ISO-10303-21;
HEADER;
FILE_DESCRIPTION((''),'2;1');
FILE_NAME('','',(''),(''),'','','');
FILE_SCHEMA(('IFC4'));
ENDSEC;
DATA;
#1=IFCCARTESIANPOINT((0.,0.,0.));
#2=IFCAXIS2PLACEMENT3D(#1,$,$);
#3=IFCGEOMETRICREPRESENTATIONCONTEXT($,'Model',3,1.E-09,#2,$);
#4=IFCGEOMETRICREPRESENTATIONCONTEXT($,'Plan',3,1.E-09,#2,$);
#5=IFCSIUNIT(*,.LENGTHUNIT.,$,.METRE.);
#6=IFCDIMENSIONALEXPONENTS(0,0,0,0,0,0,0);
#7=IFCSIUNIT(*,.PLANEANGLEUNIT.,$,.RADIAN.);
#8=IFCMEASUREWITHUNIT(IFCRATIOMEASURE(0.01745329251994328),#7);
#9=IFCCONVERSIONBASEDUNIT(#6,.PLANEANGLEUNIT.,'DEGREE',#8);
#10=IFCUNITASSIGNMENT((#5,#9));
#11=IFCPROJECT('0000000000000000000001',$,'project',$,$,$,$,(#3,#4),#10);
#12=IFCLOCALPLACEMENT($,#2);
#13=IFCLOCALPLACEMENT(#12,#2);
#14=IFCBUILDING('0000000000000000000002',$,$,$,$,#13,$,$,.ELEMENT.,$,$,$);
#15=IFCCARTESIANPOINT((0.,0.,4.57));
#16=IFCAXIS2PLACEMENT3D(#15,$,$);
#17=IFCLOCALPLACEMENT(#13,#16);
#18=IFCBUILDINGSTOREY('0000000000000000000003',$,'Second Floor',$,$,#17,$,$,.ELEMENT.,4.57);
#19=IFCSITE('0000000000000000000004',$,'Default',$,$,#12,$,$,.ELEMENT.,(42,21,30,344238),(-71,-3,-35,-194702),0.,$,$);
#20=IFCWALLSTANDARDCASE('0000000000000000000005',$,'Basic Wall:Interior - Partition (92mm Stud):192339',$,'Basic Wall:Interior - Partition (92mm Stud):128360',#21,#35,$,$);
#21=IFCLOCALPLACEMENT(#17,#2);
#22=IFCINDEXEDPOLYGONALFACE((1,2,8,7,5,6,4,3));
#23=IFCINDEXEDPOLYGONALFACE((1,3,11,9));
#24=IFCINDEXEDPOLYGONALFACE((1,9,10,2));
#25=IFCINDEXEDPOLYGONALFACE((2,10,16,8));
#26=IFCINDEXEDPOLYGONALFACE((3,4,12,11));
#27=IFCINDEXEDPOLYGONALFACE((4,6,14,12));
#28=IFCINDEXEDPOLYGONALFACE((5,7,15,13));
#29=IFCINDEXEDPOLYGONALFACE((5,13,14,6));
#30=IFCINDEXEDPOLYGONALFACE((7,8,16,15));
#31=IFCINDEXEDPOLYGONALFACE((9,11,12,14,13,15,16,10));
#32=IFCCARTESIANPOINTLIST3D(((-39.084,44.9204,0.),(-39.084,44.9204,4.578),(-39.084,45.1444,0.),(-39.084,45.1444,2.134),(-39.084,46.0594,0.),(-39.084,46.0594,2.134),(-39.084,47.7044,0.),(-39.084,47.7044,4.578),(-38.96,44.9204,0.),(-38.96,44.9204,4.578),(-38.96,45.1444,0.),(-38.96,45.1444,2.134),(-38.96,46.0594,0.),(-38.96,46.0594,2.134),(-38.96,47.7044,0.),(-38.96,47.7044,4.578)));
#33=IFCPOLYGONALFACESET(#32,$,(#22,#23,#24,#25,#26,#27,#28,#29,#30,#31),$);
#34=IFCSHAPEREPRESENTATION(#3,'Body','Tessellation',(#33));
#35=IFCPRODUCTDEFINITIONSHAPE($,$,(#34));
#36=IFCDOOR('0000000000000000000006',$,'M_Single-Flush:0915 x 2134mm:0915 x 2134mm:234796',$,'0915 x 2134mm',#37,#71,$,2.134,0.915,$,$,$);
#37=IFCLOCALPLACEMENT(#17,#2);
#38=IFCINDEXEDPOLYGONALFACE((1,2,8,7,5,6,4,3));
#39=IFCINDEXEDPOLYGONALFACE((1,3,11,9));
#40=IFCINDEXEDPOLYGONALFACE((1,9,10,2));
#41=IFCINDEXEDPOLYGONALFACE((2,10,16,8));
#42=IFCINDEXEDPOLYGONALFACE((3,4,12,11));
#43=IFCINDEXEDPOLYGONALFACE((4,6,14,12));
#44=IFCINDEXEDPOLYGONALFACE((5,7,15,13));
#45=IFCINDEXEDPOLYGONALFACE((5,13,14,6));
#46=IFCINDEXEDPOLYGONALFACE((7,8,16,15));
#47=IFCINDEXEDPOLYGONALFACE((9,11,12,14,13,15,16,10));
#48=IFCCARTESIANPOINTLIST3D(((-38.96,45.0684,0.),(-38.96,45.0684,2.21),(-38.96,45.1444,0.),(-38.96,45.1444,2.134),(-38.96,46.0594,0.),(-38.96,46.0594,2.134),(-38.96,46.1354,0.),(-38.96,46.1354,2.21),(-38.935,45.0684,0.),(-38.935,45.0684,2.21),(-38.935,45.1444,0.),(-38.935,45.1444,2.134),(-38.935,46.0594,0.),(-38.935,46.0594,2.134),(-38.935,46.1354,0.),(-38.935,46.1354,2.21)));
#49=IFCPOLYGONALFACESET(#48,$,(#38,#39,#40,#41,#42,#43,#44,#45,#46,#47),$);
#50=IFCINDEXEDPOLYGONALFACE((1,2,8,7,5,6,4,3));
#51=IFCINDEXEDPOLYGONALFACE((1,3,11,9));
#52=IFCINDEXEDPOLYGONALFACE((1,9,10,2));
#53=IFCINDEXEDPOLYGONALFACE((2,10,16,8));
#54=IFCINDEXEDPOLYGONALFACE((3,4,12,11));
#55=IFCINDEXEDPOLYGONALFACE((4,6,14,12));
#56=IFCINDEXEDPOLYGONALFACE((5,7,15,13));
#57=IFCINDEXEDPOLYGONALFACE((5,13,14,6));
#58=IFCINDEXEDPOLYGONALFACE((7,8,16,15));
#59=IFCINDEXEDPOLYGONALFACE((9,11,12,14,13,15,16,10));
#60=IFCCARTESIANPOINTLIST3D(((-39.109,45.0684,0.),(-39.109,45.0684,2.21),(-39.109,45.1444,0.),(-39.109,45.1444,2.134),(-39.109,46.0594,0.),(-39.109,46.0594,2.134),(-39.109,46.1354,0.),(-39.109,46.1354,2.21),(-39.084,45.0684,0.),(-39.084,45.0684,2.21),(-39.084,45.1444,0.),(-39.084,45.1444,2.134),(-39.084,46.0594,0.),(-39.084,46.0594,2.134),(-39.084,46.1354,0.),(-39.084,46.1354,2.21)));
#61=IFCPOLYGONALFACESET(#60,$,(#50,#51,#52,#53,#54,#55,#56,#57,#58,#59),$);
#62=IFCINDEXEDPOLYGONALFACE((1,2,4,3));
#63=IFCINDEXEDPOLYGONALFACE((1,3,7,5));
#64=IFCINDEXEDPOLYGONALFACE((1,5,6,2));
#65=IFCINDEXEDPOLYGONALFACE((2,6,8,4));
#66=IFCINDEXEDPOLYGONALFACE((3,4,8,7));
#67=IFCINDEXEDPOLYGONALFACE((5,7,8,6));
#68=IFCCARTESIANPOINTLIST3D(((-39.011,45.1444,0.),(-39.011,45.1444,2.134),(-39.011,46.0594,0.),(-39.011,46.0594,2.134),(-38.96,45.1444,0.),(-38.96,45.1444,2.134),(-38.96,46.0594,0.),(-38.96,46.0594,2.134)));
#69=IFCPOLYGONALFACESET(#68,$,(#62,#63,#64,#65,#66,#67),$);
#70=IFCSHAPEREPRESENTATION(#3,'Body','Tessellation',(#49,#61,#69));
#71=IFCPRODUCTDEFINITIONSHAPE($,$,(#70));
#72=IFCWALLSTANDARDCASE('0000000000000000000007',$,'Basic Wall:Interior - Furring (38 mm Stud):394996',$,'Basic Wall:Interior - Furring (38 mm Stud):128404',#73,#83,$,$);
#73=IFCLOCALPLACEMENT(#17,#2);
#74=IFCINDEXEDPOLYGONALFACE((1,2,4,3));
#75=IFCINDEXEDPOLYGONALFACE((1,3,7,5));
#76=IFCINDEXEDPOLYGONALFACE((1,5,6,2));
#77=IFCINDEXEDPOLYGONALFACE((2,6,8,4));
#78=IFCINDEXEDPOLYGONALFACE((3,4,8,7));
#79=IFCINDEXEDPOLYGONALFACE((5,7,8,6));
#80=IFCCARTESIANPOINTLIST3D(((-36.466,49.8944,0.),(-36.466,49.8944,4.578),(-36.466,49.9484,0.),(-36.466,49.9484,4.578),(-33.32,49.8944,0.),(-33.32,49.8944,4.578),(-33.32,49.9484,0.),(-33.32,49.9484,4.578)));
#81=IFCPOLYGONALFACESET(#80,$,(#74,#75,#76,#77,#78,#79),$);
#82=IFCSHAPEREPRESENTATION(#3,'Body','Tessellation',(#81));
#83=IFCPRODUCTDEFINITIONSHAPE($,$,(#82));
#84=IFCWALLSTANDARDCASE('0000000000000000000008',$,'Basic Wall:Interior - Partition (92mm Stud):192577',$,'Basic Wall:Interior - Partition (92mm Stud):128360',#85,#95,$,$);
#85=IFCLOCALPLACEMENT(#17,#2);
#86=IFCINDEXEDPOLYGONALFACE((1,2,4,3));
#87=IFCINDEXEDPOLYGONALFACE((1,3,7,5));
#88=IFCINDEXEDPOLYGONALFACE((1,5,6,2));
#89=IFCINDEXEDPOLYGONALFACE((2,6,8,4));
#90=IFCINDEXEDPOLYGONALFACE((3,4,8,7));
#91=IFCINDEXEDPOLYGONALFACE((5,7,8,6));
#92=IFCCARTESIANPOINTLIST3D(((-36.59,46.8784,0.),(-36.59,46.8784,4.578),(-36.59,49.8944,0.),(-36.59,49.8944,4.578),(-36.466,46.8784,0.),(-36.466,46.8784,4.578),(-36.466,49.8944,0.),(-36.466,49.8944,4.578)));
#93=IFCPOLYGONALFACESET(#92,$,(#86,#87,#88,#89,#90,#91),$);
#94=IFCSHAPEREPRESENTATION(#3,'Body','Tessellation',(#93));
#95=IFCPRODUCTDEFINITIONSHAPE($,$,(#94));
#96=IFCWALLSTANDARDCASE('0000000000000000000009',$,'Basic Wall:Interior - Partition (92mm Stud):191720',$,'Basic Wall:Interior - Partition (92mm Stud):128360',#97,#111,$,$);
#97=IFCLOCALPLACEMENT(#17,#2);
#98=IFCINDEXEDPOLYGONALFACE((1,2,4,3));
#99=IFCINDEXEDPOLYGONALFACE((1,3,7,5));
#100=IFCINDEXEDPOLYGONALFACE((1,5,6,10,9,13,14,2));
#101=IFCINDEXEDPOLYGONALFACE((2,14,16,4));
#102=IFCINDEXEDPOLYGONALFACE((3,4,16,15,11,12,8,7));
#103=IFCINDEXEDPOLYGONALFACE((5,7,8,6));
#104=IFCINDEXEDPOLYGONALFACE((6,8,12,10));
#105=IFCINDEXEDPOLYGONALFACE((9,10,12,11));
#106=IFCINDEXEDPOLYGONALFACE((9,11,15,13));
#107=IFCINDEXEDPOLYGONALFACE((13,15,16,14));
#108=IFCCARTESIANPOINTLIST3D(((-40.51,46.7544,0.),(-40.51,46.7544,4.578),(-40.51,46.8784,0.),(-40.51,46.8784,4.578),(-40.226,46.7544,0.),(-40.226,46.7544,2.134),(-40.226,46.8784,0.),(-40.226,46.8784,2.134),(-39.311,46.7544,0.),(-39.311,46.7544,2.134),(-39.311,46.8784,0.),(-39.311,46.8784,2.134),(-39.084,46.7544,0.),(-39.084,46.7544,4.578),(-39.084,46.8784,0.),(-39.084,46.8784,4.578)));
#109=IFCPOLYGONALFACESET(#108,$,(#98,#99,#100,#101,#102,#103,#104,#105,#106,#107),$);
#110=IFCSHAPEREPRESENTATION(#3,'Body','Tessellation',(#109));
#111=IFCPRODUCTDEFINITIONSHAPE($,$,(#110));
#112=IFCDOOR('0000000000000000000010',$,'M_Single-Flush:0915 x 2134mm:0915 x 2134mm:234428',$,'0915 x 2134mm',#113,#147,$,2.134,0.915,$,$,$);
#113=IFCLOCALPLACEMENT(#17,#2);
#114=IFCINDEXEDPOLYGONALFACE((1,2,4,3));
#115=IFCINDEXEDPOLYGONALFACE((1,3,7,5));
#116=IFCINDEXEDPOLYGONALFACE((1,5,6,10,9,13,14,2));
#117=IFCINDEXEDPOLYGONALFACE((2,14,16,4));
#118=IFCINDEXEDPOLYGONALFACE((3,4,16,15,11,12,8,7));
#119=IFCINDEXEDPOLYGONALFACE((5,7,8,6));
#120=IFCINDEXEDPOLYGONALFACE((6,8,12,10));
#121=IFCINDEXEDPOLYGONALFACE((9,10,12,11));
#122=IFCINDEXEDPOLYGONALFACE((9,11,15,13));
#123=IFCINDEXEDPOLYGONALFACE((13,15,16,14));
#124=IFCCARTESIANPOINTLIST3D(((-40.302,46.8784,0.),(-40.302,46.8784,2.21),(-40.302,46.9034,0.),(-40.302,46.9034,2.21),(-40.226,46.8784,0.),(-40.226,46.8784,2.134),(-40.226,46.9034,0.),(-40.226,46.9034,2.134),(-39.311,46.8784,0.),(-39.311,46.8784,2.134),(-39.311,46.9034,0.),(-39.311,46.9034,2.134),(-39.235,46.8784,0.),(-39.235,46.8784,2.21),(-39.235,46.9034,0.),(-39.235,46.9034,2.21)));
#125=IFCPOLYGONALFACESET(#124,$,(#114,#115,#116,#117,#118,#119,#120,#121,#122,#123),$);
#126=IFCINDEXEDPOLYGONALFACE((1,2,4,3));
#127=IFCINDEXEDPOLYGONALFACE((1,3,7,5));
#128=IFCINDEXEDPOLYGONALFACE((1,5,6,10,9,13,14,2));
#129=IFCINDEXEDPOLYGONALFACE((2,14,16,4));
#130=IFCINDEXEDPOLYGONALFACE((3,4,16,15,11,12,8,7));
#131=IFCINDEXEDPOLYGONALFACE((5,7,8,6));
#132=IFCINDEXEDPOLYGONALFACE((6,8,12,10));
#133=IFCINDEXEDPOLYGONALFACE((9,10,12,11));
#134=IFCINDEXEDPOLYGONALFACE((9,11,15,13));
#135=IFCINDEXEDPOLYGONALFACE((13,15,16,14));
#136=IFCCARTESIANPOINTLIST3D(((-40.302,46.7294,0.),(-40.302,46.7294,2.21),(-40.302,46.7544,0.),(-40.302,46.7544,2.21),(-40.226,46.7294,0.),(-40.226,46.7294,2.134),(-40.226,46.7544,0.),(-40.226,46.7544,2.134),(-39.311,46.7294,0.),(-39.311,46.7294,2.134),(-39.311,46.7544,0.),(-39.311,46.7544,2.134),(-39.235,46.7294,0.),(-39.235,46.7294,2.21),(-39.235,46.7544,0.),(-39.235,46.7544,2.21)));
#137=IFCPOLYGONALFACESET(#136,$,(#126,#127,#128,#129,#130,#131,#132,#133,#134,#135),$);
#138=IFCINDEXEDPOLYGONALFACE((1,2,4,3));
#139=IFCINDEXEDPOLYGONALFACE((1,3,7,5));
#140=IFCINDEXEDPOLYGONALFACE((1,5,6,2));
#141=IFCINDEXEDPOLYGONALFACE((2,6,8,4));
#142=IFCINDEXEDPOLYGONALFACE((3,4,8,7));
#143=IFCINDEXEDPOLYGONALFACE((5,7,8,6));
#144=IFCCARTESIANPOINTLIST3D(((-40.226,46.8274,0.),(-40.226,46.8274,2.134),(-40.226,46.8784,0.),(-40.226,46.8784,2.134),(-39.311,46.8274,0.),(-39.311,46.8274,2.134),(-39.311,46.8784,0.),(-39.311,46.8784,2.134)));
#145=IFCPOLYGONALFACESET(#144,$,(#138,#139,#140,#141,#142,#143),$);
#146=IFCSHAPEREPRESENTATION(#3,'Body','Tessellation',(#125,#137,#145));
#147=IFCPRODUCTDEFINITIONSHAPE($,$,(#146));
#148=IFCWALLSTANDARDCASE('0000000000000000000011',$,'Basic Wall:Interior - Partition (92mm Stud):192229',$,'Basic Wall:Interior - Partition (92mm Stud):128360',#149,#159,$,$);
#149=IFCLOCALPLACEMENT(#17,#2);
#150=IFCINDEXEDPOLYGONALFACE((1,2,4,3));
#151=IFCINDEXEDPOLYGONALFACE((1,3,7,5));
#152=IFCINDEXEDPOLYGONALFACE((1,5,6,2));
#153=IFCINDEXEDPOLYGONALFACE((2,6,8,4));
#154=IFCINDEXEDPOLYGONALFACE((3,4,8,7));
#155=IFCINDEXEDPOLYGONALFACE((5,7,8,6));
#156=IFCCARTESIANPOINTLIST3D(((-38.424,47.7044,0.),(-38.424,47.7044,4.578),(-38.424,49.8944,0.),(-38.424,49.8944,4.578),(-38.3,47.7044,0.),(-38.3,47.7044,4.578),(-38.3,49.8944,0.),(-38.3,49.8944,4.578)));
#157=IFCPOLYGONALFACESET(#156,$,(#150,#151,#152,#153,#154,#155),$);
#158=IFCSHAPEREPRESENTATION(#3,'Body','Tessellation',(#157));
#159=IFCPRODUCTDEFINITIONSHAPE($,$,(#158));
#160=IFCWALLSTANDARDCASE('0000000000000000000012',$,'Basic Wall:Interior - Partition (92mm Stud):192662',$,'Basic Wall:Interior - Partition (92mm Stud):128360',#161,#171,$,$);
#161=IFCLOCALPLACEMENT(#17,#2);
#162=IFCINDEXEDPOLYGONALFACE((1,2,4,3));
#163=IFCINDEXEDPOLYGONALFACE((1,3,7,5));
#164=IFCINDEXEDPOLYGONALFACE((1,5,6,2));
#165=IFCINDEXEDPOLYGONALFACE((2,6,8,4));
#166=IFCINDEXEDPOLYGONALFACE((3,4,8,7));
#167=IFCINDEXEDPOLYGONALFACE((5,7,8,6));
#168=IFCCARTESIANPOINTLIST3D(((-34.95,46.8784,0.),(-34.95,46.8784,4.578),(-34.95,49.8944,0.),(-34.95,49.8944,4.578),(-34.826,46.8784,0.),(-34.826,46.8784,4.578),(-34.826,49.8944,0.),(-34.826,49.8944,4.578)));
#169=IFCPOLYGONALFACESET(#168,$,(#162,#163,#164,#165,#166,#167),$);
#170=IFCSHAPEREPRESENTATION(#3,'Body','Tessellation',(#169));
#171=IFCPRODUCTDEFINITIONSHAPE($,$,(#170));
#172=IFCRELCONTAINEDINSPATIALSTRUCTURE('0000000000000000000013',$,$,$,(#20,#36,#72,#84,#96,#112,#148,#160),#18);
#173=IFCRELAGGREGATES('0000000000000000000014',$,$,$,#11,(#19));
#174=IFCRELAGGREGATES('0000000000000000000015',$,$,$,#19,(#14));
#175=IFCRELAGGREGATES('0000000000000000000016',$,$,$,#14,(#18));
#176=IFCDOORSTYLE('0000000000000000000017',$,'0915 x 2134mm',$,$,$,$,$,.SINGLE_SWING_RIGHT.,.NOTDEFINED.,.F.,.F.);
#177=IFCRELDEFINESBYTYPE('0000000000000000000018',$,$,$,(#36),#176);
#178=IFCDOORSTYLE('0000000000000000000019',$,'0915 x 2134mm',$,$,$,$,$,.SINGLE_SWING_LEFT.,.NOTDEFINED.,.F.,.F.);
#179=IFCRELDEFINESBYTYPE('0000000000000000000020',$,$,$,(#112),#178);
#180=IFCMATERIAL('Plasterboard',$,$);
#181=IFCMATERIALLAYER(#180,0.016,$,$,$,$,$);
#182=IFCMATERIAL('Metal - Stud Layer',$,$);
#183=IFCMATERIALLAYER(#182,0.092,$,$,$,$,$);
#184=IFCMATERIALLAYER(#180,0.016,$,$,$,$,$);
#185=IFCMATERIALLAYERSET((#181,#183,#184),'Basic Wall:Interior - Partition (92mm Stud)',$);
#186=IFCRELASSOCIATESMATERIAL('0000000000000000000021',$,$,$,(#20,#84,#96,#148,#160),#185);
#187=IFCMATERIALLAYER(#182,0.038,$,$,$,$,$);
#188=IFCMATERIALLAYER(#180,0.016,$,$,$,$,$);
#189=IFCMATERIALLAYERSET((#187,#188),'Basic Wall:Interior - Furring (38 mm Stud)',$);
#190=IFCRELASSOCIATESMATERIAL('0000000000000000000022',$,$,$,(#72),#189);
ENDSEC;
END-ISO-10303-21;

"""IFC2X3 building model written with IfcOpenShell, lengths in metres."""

from ifc_helpers import new_model, entity, si_unit, converted_unit, frame, frame_2d, origin, origin_2d_with_axis, place, context, project, spatial, polyline, rectangle, outline, extrude, source, transform, mapped, material, layer, layer_set, layer_usage, type_object, type_shapes, element, fill, save


model = new_model("IFC2X3")

# Units and contexts
model_context = context("Model", 3, precision=1e-09, world=origin())
plan_context = context("Plan", 3, precision=1e-09, world=origin())
ifc_project = project(units=[si_unit("LENGTHUNIT", "METRE"), converted_unit("PLANEANGLEUNIT", "DEGREE", entity("IfcRatioMeasure", 0.01745329251994328), si_unit("PLANEANGLEUNIT", "RADIAN"), dimensions=[0, 0, 0, 0, 0, 0, 0])], contexts=[model_context, plan_context])

# Site, building, storey
site_placement = place(None, origin())
site = spatial("IfcSite", under=ifc_project, at=site_placement, Name="Default", CompositionType="ELEMENT", RefLatitude=(42, 21, 30, 344238), RefLongitude=(-71, -3, -35, -194702), RefElevation=0.0)
building_placement = place(site_placement, origin())
building = spatial("IfcBuilding", under=site, at=building_placement, CompositionType="ELEMENT")
storey_placement = place(building_placement, frame((0.0, 0.0, 4.57)))
storey = spatial("IfcBuildingStorey", under=building, at=storey_placement, Name="Second Floor", CompositionType="ELEMENT", Elevation=4.57)

# Wall, opening, door
ifc_material_1 = material(Name="Plasterboard")
ifc_layer_1 = layer(ifc_material_1, 0.016)
ifc_material_2 = material(Name="Metal - Stud Layer")
ifc_layer_2 = layer(ifc_material_2, 0.092)
ifc_layer_3 = layer(ifc_material_1, 0.016)
ifc_layer_set_1 = layer_set([ifc_layer_1, ifc_layer_2, ifc_layer_3], Name="Basic Wall:Interior - Partition (92mm Stud)")
ifc_layer_usage_1 = layer_usage(ifc_layer_set_1, "AXIS2", "NEGATIVE", 0.062)
wall_1_placement = place(storey_placement, frame((-39.022, 47.7044, 0.0), z_axis=(0.0, 0.0, 1.0), x_axis=(0.0, -1.0, 0.0)))
wall_1 = element("IfcWallStandardCase", 1, at=wall_1_placement, inside=storey, material=ifc_layer_usage_1, Name="Basic Wall:Interior - Partition (92mm Stud):192339", ObjectType="Basic Wall:Interior - Partition (92mm Stud):128360", context=model_context, shape_type="SweptSolid", body=[
    extrude(rectangle(XDim=2.784, YDim=0.124, at=frame_2d((1.392, 0.0), x_axis=(-1.0, 0.0))), origin(), (0.0, 0.0, 1.0), 4.578),
])
opening_1_placement = place(wall_1_placement, frame((1.645, -0.062, 0.0)))
opening_1 = element("IfcOpeningElement", 2, at=opening_1_placement, cuts=wall_1, ObjectType="Opening", context=model_context, shape_type="SweptSolid", body=[
    extrude(rectangle(XDim=0.915, YDim=2.134, at=frame_2d((1.067, 0.4575), x_axis=(0.0, 1.0))), frame((0.0, 0.0, 0.0), z_axis=(0.0, 1.0, 0.0), x_axis=(0.0, 0.0, 1.0)), (0.0, 0.0, 1.0), 0.124),
])
door_style_1 = type_object("IfcDoorStyle", Name="0915 x 2134mm", ConstructionType="NOTDEFINED", OperationType="SINGLE_SWING_RIGHT", ParameterTakesPrecedence=False, Sizeable=False)
shared_shape_1 = source(origin(), model_context, "Body", "SweptSolid", [
    extrude(outline(polyline([(-0.5335, -1.124), (0.5335, -1.124), (0.5335, 1.086), (0.4575, 1.086), (0.4575, -1.048), (-0.4575, -1.048), (-0.4575, 1.086), (-0.5335, 1.086), (-0.5335, -1.124)])), frame((0.4575, 0.124, 1.086), z_axis=(0.0, 1.0, 0.0), x_axis=(1.0, 0.0, 0.0)), (0.0, 0.0, 1.0), 0.025),
    extrude(outline(polyline([(-1.124, -0.5335), (1.086, -0.5335), (1.086, -0.4575), (-1.048, -0.4575), (-1.048, 0.4575), (1.086, 0.4575), (1.086, 0.5335), (-1.124, 0.5335), (-1.124, -0.5335)])), frame((0.4575, -0.025, 1.086), z_axis=(0.0, 1.0, 0.0), x_axis=(0.0, 0.0, -1.0)), (0.0, 0.0, 1.0), 0.025),
    extrude(rectangle(XDim=0.051, YDim=0.915, at=origin_2d_with_axis()), frame((0.4575, 0.0985, 0.0), z_axis=(0.0, 0.0, 1.0), x_axis=(0.0, 1.0, 0.0)), (0.0, 0.0, 1.0), 2.134),
])
type_shapes(door_style_1, [shared_shape_1])
door_1_placement = place(opening_1_placement, origin())
door_1 = element("IfcDoor", 3, at=door_1_placement, inside=storey, type_object=door_style_1, Name="M_Single-Flush:0915 x 2134mm:0915 x 2134mm:234796", ObjectType="0915 x 2134mm", OverallHeight=2.134, OverallWidth=0.915, context=model_context, shape_type="MappedRepresentation", body=[
    mapped(shared_shape_1, transform((0.0, 0.0, 0.0), scale=1.0)),
])
fill(opening_1, door_1)

# Walls
ifc_layer_4 = layer(ifc_material_2, 0.038)
ifc_layer_5 = layer(ifc_material_1, 0.016)
ifc_layer_set_2 = layer_set([ifc_layer_4, ifc_layer_5], Name="Basic Wall:Interior - Furring (38 mm Stud)")
ifc_layer_usage_2 = layer_usage(ifc_layer_set_2, "AXIS2", "NEGATIVE", 0.027)
wall_2_placement = place(storey_placement, frame((-36.466, 49.9214, 0.0)))
element("IfcWallStandardCase", 4, at=wall_2_placement, inside=storey, material=ifc_layer_usage_2, Name="Basic Wall:Interior - Furring (38 mm Stud):394996", ObjectType="Basic Wall:Interior - Furring (38 mm Stud):128404", context=model_context, shape_type="SweptSolid", body=[
    extrude(rectangle(XDim=3.146, YDim=0.054, at=frame_2d((1.573, 0.0), x_axis=(-1.0, 0.0))), origin(), (0.0, 0.0, 1.0), 4.578),
])
wall_3_placement = place(storey_placement, frame((-36.528, 46.8784, 0.0), z_axis=(0.0, 0.0, 1.0), x_axis=(0.0, 1.0, 0.0)))
element("IfcWallStandardCase", 5, at=wall_3_placement, inside=storey, material=ifc_layer_usage_1, Name="Basic Wall:Interior - Partition (92mm Stud):192577", ObjectType="Basic Wall:Interior - Partition (92mm Stud):128360", context=model_context, shape_type="SweptSolid", body=[
    extrude(rectangle(XDim=3.016, YDim=0.124, at=frame_2d((1.508, 0.0), x_axis=(-1.0, 0.0))), origin(), (0.0, 0.0, 1.0), 4.578),
])

# Wall, opening, door
wall_4_placement = place(storey_placement, frame((-39.084, 46.8164, 0.0), z_axis=(0.0, 0.0, 1.0), x_axis=(-1.0, 0.0, 0.0)))
wall_4 = element("IfcWallStandardCase", 6, at=wall_4_placement, inside=storey, material=ifc_layer_usage_1, Name="Basic Wall:Interior - Partition (92mm Stud):191720", ObjectType="Basic Wall:Interior - Partition (92mm Stud):128360", context=model_context, shape_type="SweptSolid", body=[
    extrude(rectangle(XDim=1.426, YDim=0.124, at=frame_2d((0.713, 0.0), x_axis=(-1.0, 0.0))), origin(), (0.0, 0.0, 1.0), 4.578),
])
opening_2_placement = place(wall_4_placement, frame((1.142, 0.062, 0.0)))
opening_2 = element("IfcOpeningElement", 7, at=opening_2_placement, cuts=wall_4, ObjectType="Opening", context=model_context, shape_type="SweptSolid", body=[
    extrude(rectangle(XDim=0.915, YDim=2.134, at=frame_2d((1.067, 0.4575), x_axis=(0.0, -1.0))), frame((0.0, 0.0, 0.0), z_axis=(0.0, -1.0, 0.0), x_axis=(0.0, 0.0, 1.0)), (0.0, 0.0, 1.0), 0.124),
])
door_style_2 = type_object("IfcDoorStyle", Name="0915 x 2134mm", ConstructionType="NOTDEFINED", OperationType="SINGLE_SWING_LEFT", ParameterTakesPrecedence=False, Sizeable=False)
shared_shape_2 = source(origin(), model_context, "Body", "SweptSolid", [
    extrude(outline(polyline([(-0.5335, -1.124), (0.5335, -1.124), (0.5335, 1.086), (0.4575, 1.086), (0.4575, -1.048), (-0.4575, -1.048), (-0.4575, 1.086), (-0.5335, 1.086), (-0.5335, -1.124)])), frame((0.4575, 0.149, 1.086), z_axis=(0.0, -1.0, 0.0), x_axis=(-1.0, 0.0, 0.0)), (0.0, 0.0, 1.0), 0.025),
    extrude(outline(polyline([(-1.124, -0.5335), (1.086, -0.5335), (1.086, -0.4575), (-1.048, -0.4575), (-1.048, 0.4575), (1.086, 0.4575), (1.086, 0.5335), (-1.124, 0.5335), (-1.124, -0.5335)])), frame((0.4575, 0.0, 1.086), z_axis=(0.0, -1.0, 0.0), x_axis=(0.0, 0.0, -1.0)), (0.0, 0.0, 1.0), 0.025),
    extrude(rectangle(XDim=0.915, YDim=0.051, at=origin_2d_with_axis()), frame((0.4575, 0.0985, 0.0)), (0.0, 0.0, 1.0), 2.134),
])
type_shapes(door_style_2, [shared_shape_2])
door_2_placement = place(opening_2_placement, frame((0.0, 0.0, 0.0), z_axis=(0.0, 0.0, 1.0), x_axis=(-1.0, 0.0, 0.0)))
door_2 = element("IfcDoor", 8, at=door_2_placement, inside=storey, type_object=door_style_2, Name="M_Single-Flush:0915 x 2134mm:0915 x 2134mm:234428", ObjectType="0915 x 2134mm", OverallHeight=2.134, OverallWidth=0.915, context=model_context, shape_type="MappedRepresentation", body=[
    mapped(shared_shape_2, transform((0.0, 0.0, 0.0), scale=1.0)),
])
fill(opening_2, door_2)

# Walls
wall_5_placement = place(storey_placement, frame((-38.362, 49.8944, 0.0), z_axis=(0.0, 0.0, 1.0), x_axis=(0.0, -1.0, 0.0)))
element("IfcWallStandardCase", 9, at=wall_5_placement, inside=storey, material=ifc_layer_usage_1, Name="Basic Wall:Interior - Partition (92mm Stud):192229", ObjectType="Basic Wall:Interior - Partition (92mm Stud):128360", context=model_context, shape_type="SweptSolid", body=[
    extrude(rectangle(XDim=2.19, YDim=0.124, at=frame_2d((1.095, 0.0), x_axis=(-1.0, 0.0))), origin(), (0.0, 0.0, 1.0), 4.578),
])
wall_6_placement = place(storey_placement, frame((-34.888, 46.8784, 0.0), z_axis=(0.0, 0.0, 1.0), x_axis=(0.0, 1.0, 0.0)))
element("IfcWallStandardCase", 10, at=wall_6_placement, inside=storey, material=ifc_layer_usage_1, Name="Basic Wall:Interior - Partition (92mm Stud):192662", ObjectType="Basic Wall:Interior - Partition (92mm Stud):128360", context=model_context, shape_type="SweptSolid", body=[
    extrude(rectangle(XDim=3.016, YDim=0.124, at=frame_2d((1.508, 0.0), x_axis=(-1.0, 0.0))), origin(), (0.0, 0.0, 1.0), 4.578),
])

save(model, "model.ifc")
